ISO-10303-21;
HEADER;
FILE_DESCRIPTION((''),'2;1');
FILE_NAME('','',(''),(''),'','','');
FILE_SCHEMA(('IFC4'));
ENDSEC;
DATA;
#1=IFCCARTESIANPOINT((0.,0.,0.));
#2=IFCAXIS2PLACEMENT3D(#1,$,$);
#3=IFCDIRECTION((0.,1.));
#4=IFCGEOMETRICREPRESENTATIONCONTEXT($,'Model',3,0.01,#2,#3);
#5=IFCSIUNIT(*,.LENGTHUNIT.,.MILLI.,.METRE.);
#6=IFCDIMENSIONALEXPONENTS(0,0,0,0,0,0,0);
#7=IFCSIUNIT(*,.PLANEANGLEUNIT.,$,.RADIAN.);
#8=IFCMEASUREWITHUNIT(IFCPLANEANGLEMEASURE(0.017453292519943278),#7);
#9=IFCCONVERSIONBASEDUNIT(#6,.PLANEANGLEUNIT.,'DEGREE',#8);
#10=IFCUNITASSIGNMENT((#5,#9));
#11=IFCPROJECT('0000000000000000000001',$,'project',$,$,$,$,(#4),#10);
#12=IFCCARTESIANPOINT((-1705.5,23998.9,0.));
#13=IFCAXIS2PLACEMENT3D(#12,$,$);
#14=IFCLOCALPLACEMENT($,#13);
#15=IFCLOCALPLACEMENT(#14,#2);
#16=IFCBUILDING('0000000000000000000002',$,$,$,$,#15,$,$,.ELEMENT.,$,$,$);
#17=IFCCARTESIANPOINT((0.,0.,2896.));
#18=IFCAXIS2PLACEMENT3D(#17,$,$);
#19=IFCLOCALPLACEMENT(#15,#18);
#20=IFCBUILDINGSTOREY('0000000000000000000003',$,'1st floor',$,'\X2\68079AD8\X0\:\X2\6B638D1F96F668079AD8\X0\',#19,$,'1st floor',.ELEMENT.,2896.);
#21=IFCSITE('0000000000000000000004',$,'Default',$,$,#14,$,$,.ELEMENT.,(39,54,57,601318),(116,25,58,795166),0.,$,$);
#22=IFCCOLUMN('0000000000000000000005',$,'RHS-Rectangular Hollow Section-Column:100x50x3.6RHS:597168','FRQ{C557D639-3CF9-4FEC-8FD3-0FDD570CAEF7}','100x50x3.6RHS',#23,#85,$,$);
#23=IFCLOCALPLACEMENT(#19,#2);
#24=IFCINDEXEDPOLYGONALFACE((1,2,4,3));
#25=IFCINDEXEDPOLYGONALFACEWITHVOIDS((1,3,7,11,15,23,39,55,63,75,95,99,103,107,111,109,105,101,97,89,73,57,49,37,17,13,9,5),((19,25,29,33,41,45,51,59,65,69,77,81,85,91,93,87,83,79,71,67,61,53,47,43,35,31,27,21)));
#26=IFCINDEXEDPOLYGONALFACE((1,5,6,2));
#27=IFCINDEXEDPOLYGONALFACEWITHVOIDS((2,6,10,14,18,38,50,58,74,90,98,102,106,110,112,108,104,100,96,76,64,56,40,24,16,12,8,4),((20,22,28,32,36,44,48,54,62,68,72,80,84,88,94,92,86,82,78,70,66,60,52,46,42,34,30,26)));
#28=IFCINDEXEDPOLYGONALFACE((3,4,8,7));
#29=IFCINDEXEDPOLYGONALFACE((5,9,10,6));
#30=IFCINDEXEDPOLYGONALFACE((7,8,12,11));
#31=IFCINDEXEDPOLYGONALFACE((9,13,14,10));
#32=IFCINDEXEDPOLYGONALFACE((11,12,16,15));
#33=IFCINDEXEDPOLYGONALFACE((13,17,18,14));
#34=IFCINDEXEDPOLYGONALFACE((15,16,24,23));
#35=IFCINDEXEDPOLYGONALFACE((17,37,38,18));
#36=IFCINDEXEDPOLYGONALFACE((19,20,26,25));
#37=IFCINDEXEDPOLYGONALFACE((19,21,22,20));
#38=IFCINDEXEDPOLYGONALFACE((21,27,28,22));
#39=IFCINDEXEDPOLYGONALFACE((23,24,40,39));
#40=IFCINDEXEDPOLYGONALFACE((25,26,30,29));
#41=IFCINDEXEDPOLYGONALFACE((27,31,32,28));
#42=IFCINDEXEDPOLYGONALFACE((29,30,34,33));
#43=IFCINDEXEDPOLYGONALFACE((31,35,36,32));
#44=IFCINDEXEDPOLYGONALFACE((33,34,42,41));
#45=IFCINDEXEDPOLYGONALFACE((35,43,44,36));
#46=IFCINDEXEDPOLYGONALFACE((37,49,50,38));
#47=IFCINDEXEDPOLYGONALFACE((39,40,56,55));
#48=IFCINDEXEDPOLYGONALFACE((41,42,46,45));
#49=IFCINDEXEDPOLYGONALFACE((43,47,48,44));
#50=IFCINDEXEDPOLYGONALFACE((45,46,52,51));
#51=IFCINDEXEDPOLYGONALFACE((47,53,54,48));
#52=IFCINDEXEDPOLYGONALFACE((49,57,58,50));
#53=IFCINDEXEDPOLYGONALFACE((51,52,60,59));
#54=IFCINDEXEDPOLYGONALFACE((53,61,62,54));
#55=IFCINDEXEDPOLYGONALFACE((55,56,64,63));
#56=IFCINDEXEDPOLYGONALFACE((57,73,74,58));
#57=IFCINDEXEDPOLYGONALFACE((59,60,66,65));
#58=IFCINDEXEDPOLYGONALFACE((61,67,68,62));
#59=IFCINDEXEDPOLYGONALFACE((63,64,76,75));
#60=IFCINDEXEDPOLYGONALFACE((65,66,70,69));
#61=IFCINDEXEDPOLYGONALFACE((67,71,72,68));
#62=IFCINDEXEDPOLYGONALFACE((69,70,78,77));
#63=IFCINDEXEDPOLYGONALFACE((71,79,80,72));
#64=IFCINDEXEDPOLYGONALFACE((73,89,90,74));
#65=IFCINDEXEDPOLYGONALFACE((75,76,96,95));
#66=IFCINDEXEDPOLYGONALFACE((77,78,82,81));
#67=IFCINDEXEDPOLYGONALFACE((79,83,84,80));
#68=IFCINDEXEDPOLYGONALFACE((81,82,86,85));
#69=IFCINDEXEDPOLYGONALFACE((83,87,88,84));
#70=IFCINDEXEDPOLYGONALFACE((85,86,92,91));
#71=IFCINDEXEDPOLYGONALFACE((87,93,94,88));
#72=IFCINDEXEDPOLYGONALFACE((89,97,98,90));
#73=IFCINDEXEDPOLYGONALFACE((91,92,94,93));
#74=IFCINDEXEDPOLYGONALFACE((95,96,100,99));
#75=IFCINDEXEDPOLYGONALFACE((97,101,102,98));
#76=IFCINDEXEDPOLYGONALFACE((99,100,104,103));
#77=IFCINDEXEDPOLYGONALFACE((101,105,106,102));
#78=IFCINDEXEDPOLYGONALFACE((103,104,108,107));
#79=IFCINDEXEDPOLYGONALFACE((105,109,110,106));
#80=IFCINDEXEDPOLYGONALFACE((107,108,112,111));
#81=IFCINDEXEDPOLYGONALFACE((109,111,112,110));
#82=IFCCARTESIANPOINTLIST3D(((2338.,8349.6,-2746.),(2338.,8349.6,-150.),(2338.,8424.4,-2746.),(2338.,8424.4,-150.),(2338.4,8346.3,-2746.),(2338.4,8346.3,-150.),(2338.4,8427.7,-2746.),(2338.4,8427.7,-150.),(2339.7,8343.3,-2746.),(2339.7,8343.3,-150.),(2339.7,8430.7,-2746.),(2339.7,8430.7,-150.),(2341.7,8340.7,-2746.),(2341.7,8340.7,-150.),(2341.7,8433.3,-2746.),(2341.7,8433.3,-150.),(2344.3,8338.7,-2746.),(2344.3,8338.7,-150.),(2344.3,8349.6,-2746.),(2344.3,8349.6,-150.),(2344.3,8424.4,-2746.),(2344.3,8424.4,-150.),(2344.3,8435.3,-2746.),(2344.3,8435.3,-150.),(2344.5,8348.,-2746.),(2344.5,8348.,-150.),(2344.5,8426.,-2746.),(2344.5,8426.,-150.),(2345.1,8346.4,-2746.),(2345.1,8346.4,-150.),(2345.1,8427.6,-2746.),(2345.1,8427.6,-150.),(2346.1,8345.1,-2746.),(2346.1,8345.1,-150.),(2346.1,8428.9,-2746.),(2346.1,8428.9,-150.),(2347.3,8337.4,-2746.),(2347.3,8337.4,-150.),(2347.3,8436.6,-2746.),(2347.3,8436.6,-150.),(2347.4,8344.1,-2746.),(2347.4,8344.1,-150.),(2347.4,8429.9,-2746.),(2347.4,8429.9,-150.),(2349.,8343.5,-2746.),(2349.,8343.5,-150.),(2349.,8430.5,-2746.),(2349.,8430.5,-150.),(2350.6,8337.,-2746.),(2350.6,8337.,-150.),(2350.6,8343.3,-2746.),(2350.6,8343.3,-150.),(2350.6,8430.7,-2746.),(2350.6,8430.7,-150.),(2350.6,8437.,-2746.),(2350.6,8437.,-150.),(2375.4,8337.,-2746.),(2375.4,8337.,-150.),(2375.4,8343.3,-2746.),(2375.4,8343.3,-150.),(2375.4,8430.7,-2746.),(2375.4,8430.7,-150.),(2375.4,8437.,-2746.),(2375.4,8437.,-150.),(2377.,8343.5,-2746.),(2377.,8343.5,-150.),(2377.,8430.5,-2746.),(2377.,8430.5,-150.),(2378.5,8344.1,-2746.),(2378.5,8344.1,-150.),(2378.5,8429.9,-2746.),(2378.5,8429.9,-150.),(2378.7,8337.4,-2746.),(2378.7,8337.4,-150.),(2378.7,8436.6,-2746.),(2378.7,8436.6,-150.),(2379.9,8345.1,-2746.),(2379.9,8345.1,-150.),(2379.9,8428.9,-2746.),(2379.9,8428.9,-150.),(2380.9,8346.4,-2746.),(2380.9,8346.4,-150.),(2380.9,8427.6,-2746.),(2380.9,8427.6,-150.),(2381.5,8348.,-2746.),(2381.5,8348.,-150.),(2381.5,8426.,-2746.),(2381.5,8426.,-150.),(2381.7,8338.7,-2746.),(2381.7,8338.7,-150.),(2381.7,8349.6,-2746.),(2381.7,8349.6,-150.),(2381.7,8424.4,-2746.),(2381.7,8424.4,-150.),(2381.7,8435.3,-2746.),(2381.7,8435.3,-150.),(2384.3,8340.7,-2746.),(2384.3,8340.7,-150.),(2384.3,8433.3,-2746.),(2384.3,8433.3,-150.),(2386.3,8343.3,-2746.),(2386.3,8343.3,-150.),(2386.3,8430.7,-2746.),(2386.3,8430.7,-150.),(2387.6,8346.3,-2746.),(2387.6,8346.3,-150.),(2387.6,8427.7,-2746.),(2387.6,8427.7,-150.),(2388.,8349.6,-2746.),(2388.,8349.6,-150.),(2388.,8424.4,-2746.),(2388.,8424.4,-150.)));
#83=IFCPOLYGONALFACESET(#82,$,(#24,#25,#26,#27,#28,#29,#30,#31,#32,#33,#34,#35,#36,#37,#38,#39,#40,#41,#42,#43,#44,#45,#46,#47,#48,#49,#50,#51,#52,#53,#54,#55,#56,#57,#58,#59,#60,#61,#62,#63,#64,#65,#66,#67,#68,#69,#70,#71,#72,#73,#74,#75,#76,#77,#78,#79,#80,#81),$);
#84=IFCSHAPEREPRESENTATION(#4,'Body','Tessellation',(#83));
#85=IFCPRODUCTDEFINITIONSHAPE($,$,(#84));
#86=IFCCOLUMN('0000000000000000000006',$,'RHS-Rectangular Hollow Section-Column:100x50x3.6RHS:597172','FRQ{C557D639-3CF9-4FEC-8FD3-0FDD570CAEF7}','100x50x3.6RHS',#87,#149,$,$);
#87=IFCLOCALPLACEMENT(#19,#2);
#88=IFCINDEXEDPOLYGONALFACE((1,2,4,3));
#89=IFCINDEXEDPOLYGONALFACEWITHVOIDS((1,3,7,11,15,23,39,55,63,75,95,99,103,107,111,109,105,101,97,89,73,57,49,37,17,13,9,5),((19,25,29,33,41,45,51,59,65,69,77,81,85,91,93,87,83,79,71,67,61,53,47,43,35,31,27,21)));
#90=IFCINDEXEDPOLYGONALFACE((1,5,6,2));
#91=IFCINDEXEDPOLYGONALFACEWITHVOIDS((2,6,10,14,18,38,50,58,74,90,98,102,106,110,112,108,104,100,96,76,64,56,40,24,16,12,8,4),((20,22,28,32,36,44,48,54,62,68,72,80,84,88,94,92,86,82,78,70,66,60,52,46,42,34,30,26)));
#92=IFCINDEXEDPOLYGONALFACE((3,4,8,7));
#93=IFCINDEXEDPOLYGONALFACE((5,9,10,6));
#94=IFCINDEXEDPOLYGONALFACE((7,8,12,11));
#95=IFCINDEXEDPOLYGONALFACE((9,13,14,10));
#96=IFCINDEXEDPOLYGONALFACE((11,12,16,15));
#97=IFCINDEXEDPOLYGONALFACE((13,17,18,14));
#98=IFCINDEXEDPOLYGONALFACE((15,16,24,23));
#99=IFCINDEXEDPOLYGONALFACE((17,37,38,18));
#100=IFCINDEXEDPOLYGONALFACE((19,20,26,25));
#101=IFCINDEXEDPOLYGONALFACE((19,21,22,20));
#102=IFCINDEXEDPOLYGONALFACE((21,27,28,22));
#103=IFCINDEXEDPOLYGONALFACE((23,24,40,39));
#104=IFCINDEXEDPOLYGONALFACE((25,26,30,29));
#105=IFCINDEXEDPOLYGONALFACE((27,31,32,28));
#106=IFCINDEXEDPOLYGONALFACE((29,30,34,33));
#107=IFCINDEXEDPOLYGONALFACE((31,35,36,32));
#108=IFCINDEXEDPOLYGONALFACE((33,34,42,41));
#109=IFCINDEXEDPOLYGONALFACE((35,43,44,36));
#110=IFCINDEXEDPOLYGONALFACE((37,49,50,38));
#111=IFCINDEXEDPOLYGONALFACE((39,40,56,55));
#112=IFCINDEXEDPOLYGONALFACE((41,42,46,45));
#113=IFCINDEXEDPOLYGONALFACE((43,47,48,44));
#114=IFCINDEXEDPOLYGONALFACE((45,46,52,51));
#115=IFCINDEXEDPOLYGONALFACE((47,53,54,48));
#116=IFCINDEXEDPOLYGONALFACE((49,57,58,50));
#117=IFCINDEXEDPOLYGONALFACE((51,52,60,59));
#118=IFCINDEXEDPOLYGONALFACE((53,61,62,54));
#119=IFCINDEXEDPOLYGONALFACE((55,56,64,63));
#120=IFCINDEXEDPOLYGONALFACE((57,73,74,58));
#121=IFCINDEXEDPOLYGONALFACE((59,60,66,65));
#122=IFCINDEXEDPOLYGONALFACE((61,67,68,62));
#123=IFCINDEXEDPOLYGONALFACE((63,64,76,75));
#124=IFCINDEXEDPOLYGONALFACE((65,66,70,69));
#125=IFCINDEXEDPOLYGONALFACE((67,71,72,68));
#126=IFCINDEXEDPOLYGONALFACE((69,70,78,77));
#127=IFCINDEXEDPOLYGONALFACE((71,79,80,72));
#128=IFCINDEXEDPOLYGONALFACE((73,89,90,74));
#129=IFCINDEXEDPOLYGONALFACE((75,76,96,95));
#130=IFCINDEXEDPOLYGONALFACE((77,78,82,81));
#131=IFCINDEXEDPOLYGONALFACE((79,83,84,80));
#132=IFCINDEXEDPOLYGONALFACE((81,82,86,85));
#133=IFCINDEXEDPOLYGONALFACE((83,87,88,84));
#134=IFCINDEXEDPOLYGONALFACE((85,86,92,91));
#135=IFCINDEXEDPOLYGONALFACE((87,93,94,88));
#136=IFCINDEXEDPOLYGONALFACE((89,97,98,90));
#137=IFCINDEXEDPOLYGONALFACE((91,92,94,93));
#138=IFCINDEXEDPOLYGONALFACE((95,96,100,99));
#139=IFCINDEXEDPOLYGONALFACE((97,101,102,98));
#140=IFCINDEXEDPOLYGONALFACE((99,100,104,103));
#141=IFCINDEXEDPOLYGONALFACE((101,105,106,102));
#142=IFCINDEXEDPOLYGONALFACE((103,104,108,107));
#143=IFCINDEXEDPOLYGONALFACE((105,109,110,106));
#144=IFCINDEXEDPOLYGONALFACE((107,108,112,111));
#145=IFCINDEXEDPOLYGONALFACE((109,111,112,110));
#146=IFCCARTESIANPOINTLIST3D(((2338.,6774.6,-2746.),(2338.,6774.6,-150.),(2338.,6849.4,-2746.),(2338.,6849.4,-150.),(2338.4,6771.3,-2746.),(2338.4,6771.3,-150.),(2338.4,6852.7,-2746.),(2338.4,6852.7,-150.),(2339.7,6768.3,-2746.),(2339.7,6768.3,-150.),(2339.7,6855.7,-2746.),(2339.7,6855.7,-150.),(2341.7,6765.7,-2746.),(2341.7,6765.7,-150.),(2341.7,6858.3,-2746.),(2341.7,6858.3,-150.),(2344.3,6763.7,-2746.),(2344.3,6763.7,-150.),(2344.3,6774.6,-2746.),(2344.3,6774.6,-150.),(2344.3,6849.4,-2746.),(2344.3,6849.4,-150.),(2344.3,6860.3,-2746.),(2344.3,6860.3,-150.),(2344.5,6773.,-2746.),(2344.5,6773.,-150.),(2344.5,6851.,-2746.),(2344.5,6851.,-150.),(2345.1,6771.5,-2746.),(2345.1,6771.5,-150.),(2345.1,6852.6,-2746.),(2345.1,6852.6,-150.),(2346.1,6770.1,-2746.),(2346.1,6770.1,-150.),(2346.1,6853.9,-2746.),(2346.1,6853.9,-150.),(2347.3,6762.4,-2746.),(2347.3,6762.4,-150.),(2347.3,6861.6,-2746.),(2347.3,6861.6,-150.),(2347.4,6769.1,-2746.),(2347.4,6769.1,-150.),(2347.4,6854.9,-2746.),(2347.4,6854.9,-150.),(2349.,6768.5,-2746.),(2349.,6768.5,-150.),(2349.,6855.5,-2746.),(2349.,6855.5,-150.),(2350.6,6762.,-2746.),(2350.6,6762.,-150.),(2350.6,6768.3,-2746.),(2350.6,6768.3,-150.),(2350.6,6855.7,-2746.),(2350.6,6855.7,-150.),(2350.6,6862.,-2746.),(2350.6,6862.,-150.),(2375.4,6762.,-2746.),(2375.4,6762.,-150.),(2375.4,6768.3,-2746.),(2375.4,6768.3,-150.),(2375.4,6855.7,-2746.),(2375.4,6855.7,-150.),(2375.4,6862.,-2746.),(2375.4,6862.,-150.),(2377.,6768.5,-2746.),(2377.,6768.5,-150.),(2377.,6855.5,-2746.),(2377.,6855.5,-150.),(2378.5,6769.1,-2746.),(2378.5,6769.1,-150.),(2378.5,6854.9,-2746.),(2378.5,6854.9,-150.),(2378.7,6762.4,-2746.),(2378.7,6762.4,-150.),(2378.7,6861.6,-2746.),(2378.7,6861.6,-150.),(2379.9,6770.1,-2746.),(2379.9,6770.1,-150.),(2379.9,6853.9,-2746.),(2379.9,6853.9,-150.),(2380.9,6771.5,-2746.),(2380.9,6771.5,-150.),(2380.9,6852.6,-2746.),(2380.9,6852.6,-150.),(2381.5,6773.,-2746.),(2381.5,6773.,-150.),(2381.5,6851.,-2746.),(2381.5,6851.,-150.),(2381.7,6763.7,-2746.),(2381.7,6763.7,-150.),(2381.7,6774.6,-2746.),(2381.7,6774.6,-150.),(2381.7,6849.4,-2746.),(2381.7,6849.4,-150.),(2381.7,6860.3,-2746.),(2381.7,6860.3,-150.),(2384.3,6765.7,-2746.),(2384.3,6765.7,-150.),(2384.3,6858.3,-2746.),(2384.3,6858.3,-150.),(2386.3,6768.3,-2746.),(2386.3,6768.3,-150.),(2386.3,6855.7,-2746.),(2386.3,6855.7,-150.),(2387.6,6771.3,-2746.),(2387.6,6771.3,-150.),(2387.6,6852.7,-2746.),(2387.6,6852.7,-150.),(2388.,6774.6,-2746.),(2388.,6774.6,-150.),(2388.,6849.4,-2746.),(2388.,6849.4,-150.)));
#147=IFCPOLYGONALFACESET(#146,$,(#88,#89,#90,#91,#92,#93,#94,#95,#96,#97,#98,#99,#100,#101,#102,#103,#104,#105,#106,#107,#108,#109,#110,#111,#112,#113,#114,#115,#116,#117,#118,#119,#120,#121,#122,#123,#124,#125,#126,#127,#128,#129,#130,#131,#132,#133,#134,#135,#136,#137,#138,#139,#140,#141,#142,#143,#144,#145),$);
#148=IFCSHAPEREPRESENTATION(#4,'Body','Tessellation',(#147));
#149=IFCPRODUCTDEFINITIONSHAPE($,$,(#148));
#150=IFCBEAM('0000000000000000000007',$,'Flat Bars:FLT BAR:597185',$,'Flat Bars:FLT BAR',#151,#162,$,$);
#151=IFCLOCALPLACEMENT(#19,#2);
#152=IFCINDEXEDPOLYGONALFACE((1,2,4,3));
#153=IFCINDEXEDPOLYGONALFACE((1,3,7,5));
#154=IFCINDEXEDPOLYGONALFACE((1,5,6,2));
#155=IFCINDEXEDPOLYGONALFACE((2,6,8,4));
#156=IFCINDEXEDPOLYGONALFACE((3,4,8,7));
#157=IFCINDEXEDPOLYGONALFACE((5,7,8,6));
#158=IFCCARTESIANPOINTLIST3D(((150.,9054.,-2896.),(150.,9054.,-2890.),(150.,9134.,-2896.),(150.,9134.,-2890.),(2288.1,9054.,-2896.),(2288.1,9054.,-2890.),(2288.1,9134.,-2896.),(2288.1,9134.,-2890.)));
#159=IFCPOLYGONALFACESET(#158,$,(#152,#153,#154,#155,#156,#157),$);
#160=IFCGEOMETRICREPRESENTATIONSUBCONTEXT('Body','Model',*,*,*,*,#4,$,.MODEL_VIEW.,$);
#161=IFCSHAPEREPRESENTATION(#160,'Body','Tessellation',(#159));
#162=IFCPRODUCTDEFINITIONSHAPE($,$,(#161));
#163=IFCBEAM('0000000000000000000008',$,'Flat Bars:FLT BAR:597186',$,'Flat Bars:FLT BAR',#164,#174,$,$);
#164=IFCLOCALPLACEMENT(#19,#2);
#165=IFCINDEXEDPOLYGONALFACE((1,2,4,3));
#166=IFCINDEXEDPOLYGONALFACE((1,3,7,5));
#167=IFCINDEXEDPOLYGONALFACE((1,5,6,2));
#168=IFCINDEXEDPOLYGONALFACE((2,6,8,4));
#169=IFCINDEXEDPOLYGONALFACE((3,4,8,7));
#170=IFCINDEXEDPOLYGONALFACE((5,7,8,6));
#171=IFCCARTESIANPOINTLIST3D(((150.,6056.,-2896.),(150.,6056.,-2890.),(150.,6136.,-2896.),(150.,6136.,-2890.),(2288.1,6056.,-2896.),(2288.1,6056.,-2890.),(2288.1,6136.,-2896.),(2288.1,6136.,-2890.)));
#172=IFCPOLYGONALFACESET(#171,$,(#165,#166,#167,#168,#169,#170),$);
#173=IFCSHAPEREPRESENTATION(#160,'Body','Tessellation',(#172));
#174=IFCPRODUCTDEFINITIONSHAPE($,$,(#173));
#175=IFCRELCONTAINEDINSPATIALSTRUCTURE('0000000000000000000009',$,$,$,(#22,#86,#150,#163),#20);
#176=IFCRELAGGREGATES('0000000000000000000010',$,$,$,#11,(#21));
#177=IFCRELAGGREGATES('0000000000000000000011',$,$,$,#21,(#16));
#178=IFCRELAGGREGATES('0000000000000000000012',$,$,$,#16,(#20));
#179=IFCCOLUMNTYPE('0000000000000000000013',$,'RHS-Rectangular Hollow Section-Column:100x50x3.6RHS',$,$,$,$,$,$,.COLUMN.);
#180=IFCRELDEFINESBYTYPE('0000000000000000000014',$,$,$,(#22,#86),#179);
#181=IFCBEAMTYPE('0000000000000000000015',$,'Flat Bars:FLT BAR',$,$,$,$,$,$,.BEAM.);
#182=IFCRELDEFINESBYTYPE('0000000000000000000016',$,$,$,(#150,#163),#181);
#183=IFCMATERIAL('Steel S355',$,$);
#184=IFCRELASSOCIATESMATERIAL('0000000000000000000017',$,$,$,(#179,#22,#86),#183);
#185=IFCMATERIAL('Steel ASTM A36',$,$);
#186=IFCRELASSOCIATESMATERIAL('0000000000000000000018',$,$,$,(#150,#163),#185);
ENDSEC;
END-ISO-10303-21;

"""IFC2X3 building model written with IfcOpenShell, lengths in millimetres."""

from ifc_helpers import new_model, entity, si_unit, converted_unit, direction, frame, origin, origin_2d, origin_2d_with_axis, place, context, subcontext, project, spatial, rectangle, hollow_rectangle, extrude, clip, halfspace, material, type_object, element, save


model = new_model("IFC2X3")

# Units and contexts
model_context = context("Model", 3, precision=0.01, world=origin(), true_north=direction((0.0, 1.0)))
body_context = subcontext(model_context, "Body", "Model", "MODEL_VIEW")
ifc_project = project(units=[si_unit("LENGTHUNIT", "METRE", prefix="MILLI"), converted_unit("PLANEANGLEUNIT", "DEGREE", entity("IfcPlaneAngleMeasure", 0.017453292519943278), si_unit("PLANEANGLEUNIT", "RADIAN"), dimensions=[0, 0, 0, 0, 0, 0, 0])], contexts=[model_context])

# Site, building, storey
site_placement = place(None, frame((-1705.5, 23998.9, 0.0)))
site = spatial("IfcSite", under=ifc_project, at=site_placement, Name="Default", CompositionType="ELEMENT", RefLatitude=(39, 54, 57, 601318), RefLongitude=(116, 25, 58, 795166), RefElevation=0.0)
building_placement = place(site_placement, origin())
building = spatial("IfcBuilding", under=site, at=building_placement, CompositionType="ELEMENT")
storey_placement = place(building_placement, frame((0.0, 0.0, 2896.0)))
storey = spatial("IfcBuildingStorey", under=building, at=storey_placement, Name="1st floor", ObjectType="标高:正负零标高", LongName="1st floor", CompositionType="ELEMENT", Elevation=2896.0)

# Shared definitions
ifc_material_1 = material(Name="Steel S355")

# Columns
column_type_1 = type_object("IfcColumnType", Name="RHS-Rectangular Hollow Section-Column:100x50x3.6RHS", PredefinedType="COLUMN", material=ifc_material_1)
column_1_placement = place(storey_placement, frame((2363.0, 8387.0, -150.0), z_axis=(0.0, 0.0, 1.0), x_axis=(-1.0, 0.0, 0.0)))
element("IfcColumn", 1, at=column_1_placement, inside=storey, type_object=column_type_1, material=ifc_material_1, Name="RHS-Rectangular Hollow Section-Column:100x50x3.6RHS:597168", Description="FRQ{C557D639-3CF9-4FEC-8FD3-0FDD570CAEF7}", ObjectType="100x50x3.6RHS", context=model_context, shape_type="Clipping", body=[
    clip(extrude(hollow_rectangle(XDim=50.0, YDim=100.0, WallThickness=6.3, InnerFilletRadius=6.3, OuterFilletRadius=12.6, at=origin_2d()), origin(), (0.0, 0.0, -1.0), 2651.9), halfspace(frame((2363.0, 8387.0, -2596.0), z_axis=(0.0, 0.0, 1.0), x_axis=(-1.0, 0.0, 0.0)), True)),
])
column_2_placement = place(storey_placement, frame((2363.0, 6812.0, -150.0), z_axis=(0.0, 0.0, 1.0), x_axis=(-1.0, 0.0, 0.0)))
element("IfcColumn", 2, at=column_2_placement, inside=storey, type_object=column_type_1, material=ifc_material_1, Name="RHS-Rectangular Hollow Section-Column:100x50x3.6RHS:597172", Description="FRQ{C557D639-3CF9-4FEC-8FD3-0FDD570CAEF7}", ObjectType="100x50x3.6RHS", context=model_context, shape_type="Clipping", body=[
    clip(extrude(hollow_rectangle(XDim=50.0, YDim=100.0, WallThickness=6.3, InnerFilletRadius=6.3, OuterFilletRadius=12.6, at=origin_2d()), origin(), (0.0, 0.0, -1.0), 2651.9), halfspace(frame((2363.0, 6812.0, -2596.0), z_axis=(0.0, 0.0, 1.0), x_axis=(-1.0, 0.0, 0.0)), True)),
])

# Beams
ifc_material_2 = material(Name="Steel ASTM A36")
beam_type_1 = type_object("IfcBeamType", Name="Flat Bars:FLT BAR", PredefinedType="BEAM")
for number, where, name in (
    (3, (150.0, 9094.0, -2890.0), "Flat Bars:FLT BAR:597185"),
    (4, (150.0, 6096.0, -2890.0), "Flat Bars:FLT BAR:597186"),
):
    element("IfcBeam", number, at=place(storey_placement, frame(where)), inside=storey, type_object=beam_type_1, material=ifc_material_2, Name=name, ObjectType="Flat Bars:FLT BAR", context=body_context, shape_type="SweptSolid", body=[
        extrude(rectangle(XDim=6.0, YDim=80.0, at=origin_2d_with_axis()), frame((0.0, 0.0, -3.0), z_axis=(1.0, 0.0, 0.0), x_axis=(0.0, 0.0, -1.0)), (0.0, 0.0, 1.0), 2138.1),
    ])

save(model, "model.ifc")
